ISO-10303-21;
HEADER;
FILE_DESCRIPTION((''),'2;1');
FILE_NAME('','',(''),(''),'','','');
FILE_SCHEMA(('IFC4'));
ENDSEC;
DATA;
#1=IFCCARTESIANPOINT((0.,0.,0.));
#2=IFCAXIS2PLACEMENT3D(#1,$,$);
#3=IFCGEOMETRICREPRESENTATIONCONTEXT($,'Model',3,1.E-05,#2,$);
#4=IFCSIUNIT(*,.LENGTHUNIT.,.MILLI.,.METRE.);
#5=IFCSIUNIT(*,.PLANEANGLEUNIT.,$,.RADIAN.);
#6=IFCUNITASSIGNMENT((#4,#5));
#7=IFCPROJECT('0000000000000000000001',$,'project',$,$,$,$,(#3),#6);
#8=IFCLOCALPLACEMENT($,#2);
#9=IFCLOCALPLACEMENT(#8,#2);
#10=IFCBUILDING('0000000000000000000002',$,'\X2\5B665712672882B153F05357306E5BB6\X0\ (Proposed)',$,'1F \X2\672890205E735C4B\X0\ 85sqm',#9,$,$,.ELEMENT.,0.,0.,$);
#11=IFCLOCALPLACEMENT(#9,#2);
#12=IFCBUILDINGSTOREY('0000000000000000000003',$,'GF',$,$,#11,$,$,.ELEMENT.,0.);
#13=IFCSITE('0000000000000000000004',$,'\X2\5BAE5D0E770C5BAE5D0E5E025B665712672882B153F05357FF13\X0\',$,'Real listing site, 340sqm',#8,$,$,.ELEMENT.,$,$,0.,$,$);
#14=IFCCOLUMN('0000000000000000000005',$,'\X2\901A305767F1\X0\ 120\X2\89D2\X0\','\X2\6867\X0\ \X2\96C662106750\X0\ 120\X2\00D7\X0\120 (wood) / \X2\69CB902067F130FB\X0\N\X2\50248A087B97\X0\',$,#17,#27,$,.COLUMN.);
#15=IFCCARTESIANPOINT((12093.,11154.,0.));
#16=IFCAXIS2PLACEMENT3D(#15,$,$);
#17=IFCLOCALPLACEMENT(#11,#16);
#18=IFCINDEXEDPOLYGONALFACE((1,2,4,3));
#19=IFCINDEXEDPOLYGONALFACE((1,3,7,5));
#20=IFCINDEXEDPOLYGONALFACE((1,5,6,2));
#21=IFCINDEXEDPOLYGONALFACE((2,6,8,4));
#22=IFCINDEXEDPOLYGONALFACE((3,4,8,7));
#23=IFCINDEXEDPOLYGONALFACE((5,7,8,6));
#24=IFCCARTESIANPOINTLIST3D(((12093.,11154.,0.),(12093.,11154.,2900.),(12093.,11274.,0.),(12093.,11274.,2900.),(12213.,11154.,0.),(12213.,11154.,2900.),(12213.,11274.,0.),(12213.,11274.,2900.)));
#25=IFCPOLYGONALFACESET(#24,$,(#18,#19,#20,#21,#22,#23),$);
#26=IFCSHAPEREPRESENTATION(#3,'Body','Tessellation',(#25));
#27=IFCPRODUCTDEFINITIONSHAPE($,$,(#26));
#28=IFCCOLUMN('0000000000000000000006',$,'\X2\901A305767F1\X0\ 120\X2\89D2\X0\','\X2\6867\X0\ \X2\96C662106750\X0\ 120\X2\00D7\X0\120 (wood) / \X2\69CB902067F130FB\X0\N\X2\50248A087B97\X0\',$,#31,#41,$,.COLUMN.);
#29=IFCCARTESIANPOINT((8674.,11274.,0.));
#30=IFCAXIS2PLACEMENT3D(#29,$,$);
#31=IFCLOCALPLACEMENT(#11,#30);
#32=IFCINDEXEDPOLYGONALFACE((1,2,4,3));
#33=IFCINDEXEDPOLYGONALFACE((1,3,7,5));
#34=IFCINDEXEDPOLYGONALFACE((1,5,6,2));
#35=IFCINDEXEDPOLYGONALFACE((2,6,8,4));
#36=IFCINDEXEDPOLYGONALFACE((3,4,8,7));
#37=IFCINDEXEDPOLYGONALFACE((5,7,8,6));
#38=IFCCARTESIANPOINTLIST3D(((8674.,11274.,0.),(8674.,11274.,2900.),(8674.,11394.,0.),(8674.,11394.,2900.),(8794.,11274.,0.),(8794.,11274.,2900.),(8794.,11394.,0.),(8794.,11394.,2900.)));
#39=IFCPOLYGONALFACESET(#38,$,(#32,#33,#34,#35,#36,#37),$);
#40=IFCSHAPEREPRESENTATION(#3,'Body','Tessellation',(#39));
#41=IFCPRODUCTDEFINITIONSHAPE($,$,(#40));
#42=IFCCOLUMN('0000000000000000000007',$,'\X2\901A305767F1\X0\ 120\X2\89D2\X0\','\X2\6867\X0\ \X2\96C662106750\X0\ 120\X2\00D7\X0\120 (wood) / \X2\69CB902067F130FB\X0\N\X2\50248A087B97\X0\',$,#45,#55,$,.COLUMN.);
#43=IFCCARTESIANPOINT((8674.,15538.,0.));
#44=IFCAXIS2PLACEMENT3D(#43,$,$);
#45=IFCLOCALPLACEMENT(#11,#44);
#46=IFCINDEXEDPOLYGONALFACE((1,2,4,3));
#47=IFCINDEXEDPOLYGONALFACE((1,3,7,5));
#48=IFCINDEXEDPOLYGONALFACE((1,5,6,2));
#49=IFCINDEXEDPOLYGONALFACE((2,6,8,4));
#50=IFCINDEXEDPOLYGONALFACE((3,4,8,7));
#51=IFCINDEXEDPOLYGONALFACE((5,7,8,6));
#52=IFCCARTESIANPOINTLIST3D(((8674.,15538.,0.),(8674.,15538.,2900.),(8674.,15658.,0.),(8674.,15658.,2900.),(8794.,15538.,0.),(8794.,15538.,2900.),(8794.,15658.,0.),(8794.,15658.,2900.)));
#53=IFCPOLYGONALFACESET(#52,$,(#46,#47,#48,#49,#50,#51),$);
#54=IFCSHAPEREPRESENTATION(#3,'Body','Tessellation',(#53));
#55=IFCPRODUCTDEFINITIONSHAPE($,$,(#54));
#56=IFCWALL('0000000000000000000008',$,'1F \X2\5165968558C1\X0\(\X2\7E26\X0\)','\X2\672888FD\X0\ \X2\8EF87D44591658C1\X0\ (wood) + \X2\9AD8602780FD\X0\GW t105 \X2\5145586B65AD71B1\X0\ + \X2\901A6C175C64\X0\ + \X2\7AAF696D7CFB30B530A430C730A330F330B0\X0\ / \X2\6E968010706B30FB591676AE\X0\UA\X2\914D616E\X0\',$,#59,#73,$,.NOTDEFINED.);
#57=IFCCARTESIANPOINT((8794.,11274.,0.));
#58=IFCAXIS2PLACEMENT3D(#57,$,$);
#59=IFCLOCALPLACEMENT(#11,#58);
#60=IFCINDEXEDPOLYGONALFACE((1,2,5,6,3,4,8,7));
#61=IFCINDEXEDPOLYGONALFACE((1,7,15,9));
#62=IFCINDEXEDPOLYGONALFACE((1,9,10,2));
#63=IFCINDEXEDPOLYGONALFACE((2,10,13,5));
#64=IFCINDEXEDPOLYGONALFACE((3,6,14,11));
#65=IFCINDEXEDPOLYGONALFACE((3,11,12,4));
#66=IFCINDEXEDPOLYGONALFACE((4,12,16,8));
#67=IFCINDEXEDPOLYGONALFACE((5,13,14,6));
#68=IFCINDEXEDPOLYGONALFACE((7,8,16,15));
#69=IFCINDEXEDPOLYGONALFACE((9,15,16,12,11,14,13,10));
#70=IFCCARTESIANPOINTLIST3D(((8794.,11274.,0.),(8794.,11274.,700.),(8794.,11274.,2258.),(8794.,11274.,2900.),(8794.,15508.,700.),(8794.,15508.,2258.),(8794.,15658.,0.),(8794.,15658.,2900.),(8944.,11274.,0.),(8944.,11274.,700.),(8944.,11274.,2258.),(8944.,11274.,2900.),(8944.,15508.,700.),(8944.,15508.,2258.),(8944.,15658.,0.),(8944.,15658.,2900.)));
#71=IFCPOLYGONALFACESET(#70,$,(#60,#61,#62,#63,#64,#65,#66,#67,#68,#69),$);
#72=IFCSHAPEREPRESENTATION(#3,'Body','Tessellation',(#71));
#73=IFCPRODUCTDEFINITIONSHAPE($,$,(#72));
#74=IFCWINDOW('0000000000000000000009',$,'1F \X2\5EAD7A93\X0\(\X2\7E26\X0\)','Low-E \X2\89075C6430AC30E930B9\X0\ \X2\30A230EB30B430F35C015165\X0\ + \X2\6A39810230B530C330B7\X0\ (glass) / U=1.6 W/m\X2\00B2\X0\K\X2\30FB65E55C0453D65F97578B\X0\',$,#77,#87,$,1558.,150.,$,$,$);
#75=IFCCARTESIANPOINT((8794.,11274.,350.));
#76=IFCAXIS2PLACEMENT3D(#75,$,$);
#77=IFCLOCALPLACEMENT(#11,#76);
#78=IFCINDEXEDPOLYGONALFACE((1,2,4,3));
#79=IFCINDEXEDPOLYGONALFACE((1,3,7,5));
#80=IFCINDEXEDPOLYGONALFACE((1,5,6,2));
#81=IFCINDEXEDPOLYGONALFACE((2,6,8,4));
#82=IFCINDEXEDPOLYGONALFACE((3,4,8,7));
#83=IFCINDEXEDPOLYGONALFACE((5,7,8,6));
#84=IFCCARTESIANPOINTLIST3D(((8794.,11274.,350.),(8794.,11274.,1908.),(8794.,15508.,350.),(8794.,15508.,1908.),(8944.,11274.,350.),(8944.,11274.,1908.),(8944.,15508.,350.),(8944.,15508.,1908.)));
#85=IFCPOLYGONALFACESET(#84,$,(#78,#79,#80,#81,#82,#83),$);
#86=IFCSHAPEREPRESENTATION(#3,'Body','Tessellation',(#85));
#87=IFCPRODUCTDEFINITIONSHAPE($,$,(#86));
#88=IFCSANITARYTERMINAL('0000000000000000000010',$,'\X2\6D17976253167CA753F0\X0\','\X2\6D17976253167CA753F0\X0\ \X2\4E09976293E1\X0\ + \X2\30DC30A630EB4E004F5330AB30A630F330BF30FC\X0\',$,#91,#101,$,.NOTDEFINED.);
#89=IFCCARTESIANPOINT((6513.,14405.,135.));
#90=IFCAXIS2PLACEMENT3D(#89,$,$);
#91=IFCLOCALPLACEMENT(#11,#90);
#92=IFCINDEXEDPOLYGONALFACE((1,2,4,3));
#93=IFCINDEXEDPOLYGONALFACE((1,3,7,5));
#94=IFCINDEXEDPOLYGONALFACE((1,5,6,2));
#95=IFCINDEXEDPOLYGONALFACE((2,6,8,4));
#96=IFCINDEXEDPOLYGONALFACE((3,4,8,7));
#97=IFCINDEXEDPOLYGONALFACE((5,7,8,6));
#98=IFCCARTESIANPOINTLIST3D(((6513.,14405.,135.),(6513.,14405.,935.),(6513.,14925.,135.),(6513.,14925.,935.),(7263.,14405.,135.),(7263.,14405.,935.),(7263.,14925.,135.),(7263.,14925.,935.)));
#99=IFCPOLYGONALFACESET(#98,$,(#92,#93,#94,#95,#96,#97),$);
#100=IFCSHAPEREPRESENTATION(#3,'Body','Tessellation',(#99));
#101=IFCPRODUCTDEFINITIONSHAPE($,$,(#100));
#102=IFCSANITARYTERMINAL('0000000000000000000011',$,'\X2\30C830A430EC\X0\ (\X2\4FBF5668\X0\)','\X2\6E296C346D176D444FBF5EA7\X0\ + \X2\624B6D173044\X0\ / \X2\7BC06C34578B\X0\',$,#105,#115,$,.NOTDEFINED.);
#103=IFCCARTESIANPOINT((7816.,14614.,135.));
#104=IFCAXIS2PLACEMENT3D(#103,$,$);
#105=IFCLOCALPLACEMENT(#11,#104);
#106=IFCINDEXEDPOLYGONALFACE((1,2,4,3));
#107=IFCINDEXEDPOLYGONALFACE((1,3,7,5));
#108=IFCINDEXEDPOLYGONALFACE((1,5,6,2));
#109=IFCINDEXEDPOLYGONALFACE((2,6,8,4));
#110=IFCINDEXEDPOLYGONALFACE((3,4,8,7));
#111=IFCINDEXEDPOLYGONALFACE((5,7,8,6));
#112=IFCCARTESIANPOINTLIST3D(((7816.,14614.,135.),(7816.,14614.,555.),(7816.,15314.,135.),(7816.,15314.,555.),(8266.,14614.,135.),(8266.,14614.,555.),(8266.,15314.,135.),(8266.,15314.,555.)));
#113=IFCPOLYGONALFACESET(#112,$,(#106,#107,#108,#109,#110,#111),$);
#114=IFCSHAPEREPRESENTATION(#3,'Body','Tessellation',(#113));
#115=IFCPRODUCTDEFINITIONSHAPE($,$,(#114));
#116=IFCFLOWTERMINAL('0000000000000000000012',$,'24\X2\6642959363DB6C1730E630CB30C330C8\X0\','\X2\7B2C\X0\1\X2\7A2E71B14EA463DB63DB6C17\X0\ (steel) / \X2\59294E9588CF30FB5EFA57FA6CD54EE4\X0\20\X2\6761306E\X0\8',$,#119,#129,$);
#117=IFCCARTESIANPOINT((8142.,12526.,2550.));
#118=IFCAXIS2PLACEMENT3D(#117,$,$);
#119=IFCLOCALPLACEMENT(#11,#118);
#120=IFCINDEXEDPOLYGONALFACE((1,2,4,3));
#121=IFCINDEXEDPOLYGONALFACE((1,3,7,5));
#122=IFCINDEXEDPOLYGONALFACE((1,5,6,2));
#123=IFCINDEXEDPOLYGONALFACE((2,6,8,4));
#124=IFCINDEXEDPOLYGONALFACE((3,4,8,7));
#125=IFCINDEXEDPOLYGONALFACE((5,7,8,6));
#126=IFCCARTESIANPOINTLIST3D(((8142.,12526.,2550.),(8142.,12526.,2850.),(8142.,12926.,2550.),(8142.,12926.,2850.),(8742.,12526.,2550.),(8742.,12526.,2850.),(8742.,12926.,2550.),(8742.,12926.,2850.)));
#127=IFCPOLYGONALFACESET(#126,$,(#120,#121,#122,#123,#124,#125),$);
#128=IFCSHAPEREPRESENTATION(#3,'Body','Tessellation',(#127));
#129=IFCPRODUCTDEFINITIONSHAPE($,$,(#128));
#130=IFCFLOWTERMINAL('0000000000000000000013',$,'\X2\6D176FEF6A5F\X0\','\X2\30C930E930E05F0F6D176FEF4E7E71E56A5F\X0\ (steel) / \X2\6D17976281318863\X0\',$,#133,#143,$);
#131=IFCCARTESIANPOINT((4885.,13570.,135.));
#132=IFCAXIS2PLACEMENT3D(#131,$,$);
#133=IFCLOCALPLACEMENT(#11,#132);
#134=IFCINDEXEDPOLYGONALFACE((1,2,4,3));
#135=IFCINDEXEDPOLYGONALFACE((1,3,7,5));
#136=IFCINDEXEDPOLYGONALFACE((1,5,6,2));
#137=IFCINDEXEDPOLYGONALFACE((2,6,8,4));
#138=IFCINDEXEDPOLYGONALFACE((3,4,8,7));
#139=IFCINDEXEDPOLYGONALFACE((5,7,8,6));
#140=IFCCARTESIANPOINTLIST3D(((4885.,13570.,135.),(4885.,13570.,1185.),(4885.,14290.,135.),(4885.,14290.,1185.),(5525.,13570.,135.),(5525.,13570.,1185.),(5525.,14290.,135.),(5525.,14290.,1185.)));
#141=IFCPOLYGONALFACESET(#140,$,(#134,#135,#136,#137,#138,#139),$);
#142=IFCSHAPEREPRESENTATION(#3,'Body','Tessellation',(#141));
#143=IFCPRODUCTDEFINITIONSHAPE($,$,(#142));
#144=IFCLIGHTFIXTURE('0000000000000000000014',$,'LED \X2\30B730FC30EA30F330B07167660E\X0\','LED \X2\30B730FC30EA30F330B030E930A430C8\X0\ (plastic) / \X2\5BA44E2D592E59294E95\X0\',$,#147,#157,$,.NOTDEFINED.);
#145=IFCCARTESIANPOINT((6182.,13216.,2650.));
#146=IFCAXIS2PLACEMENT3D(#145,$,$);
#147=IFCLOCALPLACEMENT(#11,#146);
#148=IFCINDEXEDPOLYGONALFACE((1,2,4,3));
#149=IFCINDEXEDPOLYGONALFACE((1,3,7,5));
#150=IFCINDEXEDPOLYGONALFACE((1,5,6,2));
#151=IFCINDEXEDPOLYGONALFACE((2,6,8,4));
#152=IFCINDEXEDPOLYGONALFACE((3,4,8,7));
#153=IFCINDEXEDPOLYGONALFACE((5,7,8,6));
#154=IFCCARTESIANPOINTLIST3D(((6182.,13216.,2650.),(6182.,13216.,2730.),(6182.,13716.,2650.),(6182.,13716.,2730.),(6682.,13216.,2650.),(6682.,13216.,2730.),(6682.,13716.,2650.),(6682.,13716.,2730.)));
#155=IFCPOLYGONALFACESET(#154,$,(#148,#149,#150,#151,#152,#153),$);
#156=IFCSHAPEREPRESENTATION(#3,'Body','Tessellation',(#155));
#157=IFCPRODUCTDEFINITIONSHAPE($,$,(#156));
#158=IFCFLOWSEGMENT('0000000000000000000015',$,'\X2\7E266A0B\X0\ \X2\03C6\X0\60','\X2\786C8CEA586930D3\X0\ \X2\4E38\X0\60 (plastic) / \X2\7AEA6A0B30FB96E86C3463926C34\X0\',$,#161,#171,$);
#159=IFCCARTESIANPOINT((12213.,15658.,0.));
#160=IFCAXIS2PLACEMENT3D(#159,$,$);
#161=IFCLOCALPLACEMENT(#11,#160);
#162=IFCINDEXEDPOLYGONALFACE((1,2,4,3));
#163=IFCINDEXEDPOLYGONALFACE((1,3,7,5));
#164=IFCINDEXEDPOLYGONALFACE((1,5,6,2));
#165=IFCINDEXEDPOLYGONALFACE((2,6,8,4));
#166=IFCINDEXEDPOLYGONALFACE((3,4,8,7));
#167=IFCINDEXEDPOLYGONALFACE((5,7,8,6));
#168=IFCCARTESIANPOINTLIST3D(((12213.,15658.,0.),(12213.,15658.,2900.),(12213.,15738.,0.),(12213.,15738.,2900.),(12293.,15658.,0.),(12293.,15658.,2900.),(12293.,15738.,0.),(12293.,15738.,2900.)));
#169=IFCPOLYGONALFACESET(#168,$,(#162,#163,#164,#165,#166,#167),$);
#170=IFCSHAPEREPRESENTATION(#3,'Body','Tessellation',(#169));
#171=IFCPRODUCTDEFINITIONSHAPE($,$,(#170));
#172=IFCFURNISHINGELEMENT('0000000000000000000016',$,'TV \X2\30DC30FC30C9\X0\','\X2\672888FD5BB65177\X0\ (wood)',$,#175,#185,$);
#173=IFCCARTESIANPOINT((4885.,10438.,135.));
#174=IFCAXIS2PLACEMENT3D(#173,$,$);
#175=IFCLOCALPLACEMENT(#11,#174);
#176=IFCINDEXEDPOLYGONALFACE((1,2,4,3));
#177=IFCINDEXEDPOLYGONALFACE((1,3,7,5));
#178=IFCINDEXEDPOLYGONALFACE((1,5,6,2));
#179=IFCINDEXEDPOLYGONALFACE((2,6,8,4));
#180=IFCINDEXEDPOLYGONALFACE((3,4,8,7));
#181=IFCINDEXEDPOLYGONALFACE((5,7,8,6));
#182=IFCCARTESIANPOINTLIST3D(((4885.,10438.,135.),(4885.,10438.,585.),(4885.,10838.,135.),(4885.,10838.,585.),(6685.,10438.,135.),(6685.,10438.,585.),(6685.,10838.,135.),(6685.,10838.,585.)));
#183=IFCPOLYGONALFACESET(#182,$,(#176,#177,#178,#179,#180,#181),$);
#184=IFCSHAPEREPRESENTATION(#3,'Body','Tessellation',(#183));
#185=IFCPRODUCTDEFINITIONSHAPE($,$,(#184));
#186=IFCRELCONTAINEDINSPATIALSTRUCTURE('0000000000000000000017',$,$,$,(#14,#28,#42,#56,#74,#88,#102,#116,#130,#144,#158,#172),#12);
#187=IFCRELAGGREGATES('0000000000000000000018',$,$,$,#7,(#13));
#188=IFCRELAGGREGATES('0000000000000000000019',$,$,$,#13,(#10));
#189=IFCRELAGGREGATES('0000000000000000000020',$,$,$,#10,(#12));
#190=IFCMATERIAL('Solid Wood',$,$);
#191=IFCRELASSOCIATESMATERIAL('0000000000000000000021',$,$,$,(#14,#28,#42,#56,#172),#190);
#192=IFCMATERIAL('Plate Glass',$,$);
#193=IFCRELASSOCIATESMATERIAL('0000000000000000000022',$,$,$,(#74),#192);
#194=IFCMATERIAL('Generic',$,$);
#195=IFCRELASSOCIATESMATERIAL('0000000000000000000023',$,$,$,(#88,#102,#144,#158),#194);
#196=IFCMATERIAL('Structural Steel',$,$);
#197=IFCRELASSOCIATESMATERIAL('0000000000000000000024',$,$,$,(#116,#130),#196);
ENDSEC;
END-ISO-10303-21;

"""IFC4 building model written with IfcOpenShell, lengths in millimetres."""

from ifc_helpers import new_model, si_unit, frame, frame_2d, origin, place, context, project, spatial, rectangle, extrude, material, element, fill, save


model = new_model("IFC4")

# Units and contexts
model_context = context("Model", 3, precision=1e-05, world=origin())
ifc_project = project(units=[si_unit("LENGTHUNIT", "METRE", prefix="MILLI"), si_unit("PLANEANGLEUNIT", "RADIAN")], contexts=[model_context])

# Site, building, storey
site_placement = place(None, origin())
site = spatial("IfcSite", under=ifc_project, at=site_placement, Name="宮崎県宮崎市学園木花台南３", ObjectType="Real listing site, 340sqm", CompositionType="ELEMENT", RefElevation=0.0)
building_placement = place(site_placement, origin())
building = spatial("IfcBuilding", under=site, at=building_placement, Name="学園木花台南の家 (Proposed)", ObjectType="1F 木造平屋 85sqm", CompositionType="ELEMENT", ElevationOfRefHeight=0.0, ElevationOfTerrain=0.0)
storey_placement = place(building_placement, origin())
storey = spatial("IfcBuildingStorey", under=building, at=storey_placement, Name="GF", CompositionType="ELEMENT", Elevation=0.0)

# Columns
ifc_material_1 = material(Name="Solid Wood")
column_1_placement = place(storey_placement, frame((12093.0, 11154.0, 0.0)))
element("IfcColumn", 1, at=column_1_placement, inside=storey, material=ifc_material_1, Name="通し柱 120角", Description="桧 集成材 120×120 (wood) / 構造柱・N値計算", PredefinedType="COLUMN", context=model_context, shape_type="SweptSolid", body=[
    extrude(rectangle(XDim=120.0, YDim=120.0, at=frame_2d((60.0, 60.0))), frame((12093.0, 11154.0, 0.0)), (0.0, 0.0, 1.0), 2900.0),
])
column_2_placement = place(storey_placement, frame((8674.0, 11274.0, 0.0)))
element("IfcColumn", 2, at=column_2_placement, inside=storey, material=ifc_material_1, Name="通し柱 120角", Description="桧 集成材 120×120 (wood) / 構造柱・N値計算", PredefinedType="COLUMN", context=model_context, shape_type="SweptSolid", body=[
    extrude(rectangle(XDim=120.0, YDim=120.0, at=frame_2d((60.0, 60.0))), frame((8674.0, 11274.0, 0.0)), (0.0, 0.0, 1.0), 2900.0),
])
column_3_placement = place(storey_placement, frame((8674.0, 15538.0, 0.0)))
element("IfcColumn", 3, at=column_3_placement, inside=storey, material=ifc_material_1, Name="通し柱 120角", Description="桧 集成材 120×120 (wood) / 構造柱・N値計算", PredefinedType="COLUMN", context=model_context, shape_type="SweptSolid", body=[
    extrude(rectangle(XDim=120.0, YDim=120.0, at=frame_2d((60.0, 60.0))), frame((8674.0, 15538.0, 0.0)), (0.0, 0.0, 1.0), 2900.0),
])

# Wall, opening, window
wall_1_placement = place(storey_placement, frame((8794.0, 11274.0, 0.0)))
wall_1 = element("IfcWall", 4, at=wall_1_placement, inside=storey, material=ifc_material_1, Name="1F 入隅壁(縦)", Description="木製 軸組外壁 (wood) + 高性能GW t105 充填断熱 + 通気層 + 窯業系サイディング / 準耐火・外皮UA配慮", PredefinedType="NOTDEFINED", context=model_context, shape_type="SweptSolid", body=[
    extrude(rectangle(XDim=150.0, YDim=4384.0, at=frame_2d((75.0, 2192.0))), frame((8794.0, 11274.0, 0.0)), (0.0, 0.0, 1.0), 2900.0),
])
opening_placement = place(storey_placement, frame((8794.0, 11274.0, 350.0)))
opening = element("IfcOpeningElement", 5, at=opening_placement, cuts=wall_1, PredefinedType="NOTDEFINED", context=model_context, shape_type="SweptSolid", body=[
    extrude(rectangle(XDim=150.0, YDim=4234.0, at=frame_2d((75.0, 2117.0))), frame((8794.0, 11274.0, 350.0)), (0.0, 0.0, 1.0), 1558.0),
])
ifc_material_2 = material(Name="Plate Glass")
window_placement = place(storey_placement, frame((8794.0, 11274.0, 350.0)))
window = element("IfcWindow", 6, at=window_placement, inside=storey, material=ifc_material_2, Name="1F 庭窓(縦)", Description="Low-E 複層ガラス アルゴン封入 + 樹脂サッシ (glass) / U=1.6 W/m²K・日射取得型", OverallHeight=1558.0, OverallWidth=150.0, context=model_context, shape_type="SweptSolid", body=[
    extrude(rectangle(XDim=150.0, YDim=4234.0, at=frame_2d((75.0, 2117.0))), frame((8794.0, 11274.0, 350.0)), (0.0, 0.0, 1.0), 1558.0),
])
fill(opening, window)

# Sanitary terminals
ifc_material_3 = material(Name="Generic")
sanitary_terminal_1_placement = place(storey_placement, frame((6513.0, 14405.0, 135.0)))
element("IfcSanitaryTerminal", 7, at=sanitary_terminal_1_placement, inside=storey, material=ifc_material_3, Name="洗面化粧台", Description="洗面化粧台 三面鏡 + ボウル一体カウンター", PredefinedType="NOTDEFINED", context=model_context, shape_type="SweptSolid", body=[
    extrude(rectangle(XDim=750.0, YDim=520.0, at=frame_2d((375.0, 260.0))), frame((6513.0, 14405.0, 135.0)), (0.0, 0.0, 1.0), 800.0),
])
sanitary_terminal_2_placement = place(storey_placement, frame((7816.0, 14614.0, 135.0)))
element("IfcSanitaryTerminal", 8, at=sanitary_terminal_2_placement, inside=storey, material=ifc_material_3, Name="トイレ (便器)", Description="温水洗浄便座 + 手洗い / 節水型", PredefinedType="NOTDEFINED", context=model_context, shape_type="SweptSolid", body=[
    extrude(rectangle(XDim=450.0, YDim=700.0, at=frame_2d((225.0, 350.0))), frame((7816.0, 14614.0, 135.0)), (0.0, 0.0, 1.0), 420.0),
])

# Flow terminals
ifc_material_4 = material(Name="Structural Steel")
flow_terminal_1_placement = place(storey_placement, frame((8142.0, 12526.0, 2550.0)))
element("IfcFlowTerminal", 9, at=flow_terminal_1_placement, inside=storey, material=ifc_material_4, Name="24時間換気ユニット", Description="第1種熱交換換気 (steel) / 天井裏・建基法令20条の8", context=model_context, shape_type="SweptSolid", body=[
    extrude(rectangle(XDim=600.0, YDim=400.0, at=frame_2d((300.0, 200.0))), frame((8142.0, 12526.0, 2550.0)), (0.0, 0.0, 1.0), 300.0),
])
flow_terminal_2_placement = place(storey_placement, frame((4885.0, 13570.0, 135.0)))
element("IfcFlowTerminal", 10, at=flow_terminal_2_placement, inside=storey, material=ifc_material_4, Name="洗濯機", Description="ドラム式洗濯乾燥機 (steel) / 洗面脱衣", context=model_context, shape_type="SweptSolid", body=[
    extrude(rectangle(XDim=640.0, YDim=720.0, at=frame_2d((320.0, 360.0))), frame((4885.0, 13570.0, 135.0)), (0.0, 0.0, 1.0), 1050.0),
])

# Light fixture
light_fixture_placement = place(storey_placement, frame((6182.0, 13216.0, 2650.0)))
element("IfcLightFixture", 11, at=light_fixture_placement, inside=storey, material=ifc_material_3, Name="LED シーリング照明", Description="LED シーリングライト (plastic) / 室中央天井", PredefinedType="NOTDEFINED", context=model_context, shape_type="SweptSolid", body=[
    extrude(rectangle(XDim=500.0, YDim=500.0, at=frame_2d((250.0, 250.0))), frame((6182.0, 13216.0, 2650.0)), (0.0, 0.0, 1.0), 80.0),
])

# Flow segment
flow_segment_placement = place(storey_placement, frame((12213.0, 15658.0, 0.0)))
element("IfcFlowSegment", 12, at=flow_segment_placement, inside=storey, material=ifc_material_3, Name="縦樋 φ60", Description="硬質塩ビ 丸60 (plastic) / 竪樋・雨水排水", context=model_context, shape_type="SweptSolid", body=[
    extrude(rectangle(XDim=80.0, YDim=80.0, at=frame_2d((40.0, 40.0))), frame((12213.0, 15658.0, 0.0)), (0.0, 0.0, 1.0), 2900.0),
])

# Furnishing element
furnishing_placement = place(storey_placement, frame((4885.0, 10438.0, 135.0)))
element("IfcFurnishingElement", 13, at=furnishing_placement, inside=storey, material=ifc_material_1, Name="TV ボード", Description="木製家具 (wood)", context=model_context, shape_type="SweptSolid", body=[
    extrude(rectangle(XDim=1800.0, YDim=400.0, at=frame_2d((900.0, 200.0))), frame((4885.0, 10438.0, 135.0)), (0.0, 0.0, 1.0), 450.0),
])

save(model, "model.ifc")
